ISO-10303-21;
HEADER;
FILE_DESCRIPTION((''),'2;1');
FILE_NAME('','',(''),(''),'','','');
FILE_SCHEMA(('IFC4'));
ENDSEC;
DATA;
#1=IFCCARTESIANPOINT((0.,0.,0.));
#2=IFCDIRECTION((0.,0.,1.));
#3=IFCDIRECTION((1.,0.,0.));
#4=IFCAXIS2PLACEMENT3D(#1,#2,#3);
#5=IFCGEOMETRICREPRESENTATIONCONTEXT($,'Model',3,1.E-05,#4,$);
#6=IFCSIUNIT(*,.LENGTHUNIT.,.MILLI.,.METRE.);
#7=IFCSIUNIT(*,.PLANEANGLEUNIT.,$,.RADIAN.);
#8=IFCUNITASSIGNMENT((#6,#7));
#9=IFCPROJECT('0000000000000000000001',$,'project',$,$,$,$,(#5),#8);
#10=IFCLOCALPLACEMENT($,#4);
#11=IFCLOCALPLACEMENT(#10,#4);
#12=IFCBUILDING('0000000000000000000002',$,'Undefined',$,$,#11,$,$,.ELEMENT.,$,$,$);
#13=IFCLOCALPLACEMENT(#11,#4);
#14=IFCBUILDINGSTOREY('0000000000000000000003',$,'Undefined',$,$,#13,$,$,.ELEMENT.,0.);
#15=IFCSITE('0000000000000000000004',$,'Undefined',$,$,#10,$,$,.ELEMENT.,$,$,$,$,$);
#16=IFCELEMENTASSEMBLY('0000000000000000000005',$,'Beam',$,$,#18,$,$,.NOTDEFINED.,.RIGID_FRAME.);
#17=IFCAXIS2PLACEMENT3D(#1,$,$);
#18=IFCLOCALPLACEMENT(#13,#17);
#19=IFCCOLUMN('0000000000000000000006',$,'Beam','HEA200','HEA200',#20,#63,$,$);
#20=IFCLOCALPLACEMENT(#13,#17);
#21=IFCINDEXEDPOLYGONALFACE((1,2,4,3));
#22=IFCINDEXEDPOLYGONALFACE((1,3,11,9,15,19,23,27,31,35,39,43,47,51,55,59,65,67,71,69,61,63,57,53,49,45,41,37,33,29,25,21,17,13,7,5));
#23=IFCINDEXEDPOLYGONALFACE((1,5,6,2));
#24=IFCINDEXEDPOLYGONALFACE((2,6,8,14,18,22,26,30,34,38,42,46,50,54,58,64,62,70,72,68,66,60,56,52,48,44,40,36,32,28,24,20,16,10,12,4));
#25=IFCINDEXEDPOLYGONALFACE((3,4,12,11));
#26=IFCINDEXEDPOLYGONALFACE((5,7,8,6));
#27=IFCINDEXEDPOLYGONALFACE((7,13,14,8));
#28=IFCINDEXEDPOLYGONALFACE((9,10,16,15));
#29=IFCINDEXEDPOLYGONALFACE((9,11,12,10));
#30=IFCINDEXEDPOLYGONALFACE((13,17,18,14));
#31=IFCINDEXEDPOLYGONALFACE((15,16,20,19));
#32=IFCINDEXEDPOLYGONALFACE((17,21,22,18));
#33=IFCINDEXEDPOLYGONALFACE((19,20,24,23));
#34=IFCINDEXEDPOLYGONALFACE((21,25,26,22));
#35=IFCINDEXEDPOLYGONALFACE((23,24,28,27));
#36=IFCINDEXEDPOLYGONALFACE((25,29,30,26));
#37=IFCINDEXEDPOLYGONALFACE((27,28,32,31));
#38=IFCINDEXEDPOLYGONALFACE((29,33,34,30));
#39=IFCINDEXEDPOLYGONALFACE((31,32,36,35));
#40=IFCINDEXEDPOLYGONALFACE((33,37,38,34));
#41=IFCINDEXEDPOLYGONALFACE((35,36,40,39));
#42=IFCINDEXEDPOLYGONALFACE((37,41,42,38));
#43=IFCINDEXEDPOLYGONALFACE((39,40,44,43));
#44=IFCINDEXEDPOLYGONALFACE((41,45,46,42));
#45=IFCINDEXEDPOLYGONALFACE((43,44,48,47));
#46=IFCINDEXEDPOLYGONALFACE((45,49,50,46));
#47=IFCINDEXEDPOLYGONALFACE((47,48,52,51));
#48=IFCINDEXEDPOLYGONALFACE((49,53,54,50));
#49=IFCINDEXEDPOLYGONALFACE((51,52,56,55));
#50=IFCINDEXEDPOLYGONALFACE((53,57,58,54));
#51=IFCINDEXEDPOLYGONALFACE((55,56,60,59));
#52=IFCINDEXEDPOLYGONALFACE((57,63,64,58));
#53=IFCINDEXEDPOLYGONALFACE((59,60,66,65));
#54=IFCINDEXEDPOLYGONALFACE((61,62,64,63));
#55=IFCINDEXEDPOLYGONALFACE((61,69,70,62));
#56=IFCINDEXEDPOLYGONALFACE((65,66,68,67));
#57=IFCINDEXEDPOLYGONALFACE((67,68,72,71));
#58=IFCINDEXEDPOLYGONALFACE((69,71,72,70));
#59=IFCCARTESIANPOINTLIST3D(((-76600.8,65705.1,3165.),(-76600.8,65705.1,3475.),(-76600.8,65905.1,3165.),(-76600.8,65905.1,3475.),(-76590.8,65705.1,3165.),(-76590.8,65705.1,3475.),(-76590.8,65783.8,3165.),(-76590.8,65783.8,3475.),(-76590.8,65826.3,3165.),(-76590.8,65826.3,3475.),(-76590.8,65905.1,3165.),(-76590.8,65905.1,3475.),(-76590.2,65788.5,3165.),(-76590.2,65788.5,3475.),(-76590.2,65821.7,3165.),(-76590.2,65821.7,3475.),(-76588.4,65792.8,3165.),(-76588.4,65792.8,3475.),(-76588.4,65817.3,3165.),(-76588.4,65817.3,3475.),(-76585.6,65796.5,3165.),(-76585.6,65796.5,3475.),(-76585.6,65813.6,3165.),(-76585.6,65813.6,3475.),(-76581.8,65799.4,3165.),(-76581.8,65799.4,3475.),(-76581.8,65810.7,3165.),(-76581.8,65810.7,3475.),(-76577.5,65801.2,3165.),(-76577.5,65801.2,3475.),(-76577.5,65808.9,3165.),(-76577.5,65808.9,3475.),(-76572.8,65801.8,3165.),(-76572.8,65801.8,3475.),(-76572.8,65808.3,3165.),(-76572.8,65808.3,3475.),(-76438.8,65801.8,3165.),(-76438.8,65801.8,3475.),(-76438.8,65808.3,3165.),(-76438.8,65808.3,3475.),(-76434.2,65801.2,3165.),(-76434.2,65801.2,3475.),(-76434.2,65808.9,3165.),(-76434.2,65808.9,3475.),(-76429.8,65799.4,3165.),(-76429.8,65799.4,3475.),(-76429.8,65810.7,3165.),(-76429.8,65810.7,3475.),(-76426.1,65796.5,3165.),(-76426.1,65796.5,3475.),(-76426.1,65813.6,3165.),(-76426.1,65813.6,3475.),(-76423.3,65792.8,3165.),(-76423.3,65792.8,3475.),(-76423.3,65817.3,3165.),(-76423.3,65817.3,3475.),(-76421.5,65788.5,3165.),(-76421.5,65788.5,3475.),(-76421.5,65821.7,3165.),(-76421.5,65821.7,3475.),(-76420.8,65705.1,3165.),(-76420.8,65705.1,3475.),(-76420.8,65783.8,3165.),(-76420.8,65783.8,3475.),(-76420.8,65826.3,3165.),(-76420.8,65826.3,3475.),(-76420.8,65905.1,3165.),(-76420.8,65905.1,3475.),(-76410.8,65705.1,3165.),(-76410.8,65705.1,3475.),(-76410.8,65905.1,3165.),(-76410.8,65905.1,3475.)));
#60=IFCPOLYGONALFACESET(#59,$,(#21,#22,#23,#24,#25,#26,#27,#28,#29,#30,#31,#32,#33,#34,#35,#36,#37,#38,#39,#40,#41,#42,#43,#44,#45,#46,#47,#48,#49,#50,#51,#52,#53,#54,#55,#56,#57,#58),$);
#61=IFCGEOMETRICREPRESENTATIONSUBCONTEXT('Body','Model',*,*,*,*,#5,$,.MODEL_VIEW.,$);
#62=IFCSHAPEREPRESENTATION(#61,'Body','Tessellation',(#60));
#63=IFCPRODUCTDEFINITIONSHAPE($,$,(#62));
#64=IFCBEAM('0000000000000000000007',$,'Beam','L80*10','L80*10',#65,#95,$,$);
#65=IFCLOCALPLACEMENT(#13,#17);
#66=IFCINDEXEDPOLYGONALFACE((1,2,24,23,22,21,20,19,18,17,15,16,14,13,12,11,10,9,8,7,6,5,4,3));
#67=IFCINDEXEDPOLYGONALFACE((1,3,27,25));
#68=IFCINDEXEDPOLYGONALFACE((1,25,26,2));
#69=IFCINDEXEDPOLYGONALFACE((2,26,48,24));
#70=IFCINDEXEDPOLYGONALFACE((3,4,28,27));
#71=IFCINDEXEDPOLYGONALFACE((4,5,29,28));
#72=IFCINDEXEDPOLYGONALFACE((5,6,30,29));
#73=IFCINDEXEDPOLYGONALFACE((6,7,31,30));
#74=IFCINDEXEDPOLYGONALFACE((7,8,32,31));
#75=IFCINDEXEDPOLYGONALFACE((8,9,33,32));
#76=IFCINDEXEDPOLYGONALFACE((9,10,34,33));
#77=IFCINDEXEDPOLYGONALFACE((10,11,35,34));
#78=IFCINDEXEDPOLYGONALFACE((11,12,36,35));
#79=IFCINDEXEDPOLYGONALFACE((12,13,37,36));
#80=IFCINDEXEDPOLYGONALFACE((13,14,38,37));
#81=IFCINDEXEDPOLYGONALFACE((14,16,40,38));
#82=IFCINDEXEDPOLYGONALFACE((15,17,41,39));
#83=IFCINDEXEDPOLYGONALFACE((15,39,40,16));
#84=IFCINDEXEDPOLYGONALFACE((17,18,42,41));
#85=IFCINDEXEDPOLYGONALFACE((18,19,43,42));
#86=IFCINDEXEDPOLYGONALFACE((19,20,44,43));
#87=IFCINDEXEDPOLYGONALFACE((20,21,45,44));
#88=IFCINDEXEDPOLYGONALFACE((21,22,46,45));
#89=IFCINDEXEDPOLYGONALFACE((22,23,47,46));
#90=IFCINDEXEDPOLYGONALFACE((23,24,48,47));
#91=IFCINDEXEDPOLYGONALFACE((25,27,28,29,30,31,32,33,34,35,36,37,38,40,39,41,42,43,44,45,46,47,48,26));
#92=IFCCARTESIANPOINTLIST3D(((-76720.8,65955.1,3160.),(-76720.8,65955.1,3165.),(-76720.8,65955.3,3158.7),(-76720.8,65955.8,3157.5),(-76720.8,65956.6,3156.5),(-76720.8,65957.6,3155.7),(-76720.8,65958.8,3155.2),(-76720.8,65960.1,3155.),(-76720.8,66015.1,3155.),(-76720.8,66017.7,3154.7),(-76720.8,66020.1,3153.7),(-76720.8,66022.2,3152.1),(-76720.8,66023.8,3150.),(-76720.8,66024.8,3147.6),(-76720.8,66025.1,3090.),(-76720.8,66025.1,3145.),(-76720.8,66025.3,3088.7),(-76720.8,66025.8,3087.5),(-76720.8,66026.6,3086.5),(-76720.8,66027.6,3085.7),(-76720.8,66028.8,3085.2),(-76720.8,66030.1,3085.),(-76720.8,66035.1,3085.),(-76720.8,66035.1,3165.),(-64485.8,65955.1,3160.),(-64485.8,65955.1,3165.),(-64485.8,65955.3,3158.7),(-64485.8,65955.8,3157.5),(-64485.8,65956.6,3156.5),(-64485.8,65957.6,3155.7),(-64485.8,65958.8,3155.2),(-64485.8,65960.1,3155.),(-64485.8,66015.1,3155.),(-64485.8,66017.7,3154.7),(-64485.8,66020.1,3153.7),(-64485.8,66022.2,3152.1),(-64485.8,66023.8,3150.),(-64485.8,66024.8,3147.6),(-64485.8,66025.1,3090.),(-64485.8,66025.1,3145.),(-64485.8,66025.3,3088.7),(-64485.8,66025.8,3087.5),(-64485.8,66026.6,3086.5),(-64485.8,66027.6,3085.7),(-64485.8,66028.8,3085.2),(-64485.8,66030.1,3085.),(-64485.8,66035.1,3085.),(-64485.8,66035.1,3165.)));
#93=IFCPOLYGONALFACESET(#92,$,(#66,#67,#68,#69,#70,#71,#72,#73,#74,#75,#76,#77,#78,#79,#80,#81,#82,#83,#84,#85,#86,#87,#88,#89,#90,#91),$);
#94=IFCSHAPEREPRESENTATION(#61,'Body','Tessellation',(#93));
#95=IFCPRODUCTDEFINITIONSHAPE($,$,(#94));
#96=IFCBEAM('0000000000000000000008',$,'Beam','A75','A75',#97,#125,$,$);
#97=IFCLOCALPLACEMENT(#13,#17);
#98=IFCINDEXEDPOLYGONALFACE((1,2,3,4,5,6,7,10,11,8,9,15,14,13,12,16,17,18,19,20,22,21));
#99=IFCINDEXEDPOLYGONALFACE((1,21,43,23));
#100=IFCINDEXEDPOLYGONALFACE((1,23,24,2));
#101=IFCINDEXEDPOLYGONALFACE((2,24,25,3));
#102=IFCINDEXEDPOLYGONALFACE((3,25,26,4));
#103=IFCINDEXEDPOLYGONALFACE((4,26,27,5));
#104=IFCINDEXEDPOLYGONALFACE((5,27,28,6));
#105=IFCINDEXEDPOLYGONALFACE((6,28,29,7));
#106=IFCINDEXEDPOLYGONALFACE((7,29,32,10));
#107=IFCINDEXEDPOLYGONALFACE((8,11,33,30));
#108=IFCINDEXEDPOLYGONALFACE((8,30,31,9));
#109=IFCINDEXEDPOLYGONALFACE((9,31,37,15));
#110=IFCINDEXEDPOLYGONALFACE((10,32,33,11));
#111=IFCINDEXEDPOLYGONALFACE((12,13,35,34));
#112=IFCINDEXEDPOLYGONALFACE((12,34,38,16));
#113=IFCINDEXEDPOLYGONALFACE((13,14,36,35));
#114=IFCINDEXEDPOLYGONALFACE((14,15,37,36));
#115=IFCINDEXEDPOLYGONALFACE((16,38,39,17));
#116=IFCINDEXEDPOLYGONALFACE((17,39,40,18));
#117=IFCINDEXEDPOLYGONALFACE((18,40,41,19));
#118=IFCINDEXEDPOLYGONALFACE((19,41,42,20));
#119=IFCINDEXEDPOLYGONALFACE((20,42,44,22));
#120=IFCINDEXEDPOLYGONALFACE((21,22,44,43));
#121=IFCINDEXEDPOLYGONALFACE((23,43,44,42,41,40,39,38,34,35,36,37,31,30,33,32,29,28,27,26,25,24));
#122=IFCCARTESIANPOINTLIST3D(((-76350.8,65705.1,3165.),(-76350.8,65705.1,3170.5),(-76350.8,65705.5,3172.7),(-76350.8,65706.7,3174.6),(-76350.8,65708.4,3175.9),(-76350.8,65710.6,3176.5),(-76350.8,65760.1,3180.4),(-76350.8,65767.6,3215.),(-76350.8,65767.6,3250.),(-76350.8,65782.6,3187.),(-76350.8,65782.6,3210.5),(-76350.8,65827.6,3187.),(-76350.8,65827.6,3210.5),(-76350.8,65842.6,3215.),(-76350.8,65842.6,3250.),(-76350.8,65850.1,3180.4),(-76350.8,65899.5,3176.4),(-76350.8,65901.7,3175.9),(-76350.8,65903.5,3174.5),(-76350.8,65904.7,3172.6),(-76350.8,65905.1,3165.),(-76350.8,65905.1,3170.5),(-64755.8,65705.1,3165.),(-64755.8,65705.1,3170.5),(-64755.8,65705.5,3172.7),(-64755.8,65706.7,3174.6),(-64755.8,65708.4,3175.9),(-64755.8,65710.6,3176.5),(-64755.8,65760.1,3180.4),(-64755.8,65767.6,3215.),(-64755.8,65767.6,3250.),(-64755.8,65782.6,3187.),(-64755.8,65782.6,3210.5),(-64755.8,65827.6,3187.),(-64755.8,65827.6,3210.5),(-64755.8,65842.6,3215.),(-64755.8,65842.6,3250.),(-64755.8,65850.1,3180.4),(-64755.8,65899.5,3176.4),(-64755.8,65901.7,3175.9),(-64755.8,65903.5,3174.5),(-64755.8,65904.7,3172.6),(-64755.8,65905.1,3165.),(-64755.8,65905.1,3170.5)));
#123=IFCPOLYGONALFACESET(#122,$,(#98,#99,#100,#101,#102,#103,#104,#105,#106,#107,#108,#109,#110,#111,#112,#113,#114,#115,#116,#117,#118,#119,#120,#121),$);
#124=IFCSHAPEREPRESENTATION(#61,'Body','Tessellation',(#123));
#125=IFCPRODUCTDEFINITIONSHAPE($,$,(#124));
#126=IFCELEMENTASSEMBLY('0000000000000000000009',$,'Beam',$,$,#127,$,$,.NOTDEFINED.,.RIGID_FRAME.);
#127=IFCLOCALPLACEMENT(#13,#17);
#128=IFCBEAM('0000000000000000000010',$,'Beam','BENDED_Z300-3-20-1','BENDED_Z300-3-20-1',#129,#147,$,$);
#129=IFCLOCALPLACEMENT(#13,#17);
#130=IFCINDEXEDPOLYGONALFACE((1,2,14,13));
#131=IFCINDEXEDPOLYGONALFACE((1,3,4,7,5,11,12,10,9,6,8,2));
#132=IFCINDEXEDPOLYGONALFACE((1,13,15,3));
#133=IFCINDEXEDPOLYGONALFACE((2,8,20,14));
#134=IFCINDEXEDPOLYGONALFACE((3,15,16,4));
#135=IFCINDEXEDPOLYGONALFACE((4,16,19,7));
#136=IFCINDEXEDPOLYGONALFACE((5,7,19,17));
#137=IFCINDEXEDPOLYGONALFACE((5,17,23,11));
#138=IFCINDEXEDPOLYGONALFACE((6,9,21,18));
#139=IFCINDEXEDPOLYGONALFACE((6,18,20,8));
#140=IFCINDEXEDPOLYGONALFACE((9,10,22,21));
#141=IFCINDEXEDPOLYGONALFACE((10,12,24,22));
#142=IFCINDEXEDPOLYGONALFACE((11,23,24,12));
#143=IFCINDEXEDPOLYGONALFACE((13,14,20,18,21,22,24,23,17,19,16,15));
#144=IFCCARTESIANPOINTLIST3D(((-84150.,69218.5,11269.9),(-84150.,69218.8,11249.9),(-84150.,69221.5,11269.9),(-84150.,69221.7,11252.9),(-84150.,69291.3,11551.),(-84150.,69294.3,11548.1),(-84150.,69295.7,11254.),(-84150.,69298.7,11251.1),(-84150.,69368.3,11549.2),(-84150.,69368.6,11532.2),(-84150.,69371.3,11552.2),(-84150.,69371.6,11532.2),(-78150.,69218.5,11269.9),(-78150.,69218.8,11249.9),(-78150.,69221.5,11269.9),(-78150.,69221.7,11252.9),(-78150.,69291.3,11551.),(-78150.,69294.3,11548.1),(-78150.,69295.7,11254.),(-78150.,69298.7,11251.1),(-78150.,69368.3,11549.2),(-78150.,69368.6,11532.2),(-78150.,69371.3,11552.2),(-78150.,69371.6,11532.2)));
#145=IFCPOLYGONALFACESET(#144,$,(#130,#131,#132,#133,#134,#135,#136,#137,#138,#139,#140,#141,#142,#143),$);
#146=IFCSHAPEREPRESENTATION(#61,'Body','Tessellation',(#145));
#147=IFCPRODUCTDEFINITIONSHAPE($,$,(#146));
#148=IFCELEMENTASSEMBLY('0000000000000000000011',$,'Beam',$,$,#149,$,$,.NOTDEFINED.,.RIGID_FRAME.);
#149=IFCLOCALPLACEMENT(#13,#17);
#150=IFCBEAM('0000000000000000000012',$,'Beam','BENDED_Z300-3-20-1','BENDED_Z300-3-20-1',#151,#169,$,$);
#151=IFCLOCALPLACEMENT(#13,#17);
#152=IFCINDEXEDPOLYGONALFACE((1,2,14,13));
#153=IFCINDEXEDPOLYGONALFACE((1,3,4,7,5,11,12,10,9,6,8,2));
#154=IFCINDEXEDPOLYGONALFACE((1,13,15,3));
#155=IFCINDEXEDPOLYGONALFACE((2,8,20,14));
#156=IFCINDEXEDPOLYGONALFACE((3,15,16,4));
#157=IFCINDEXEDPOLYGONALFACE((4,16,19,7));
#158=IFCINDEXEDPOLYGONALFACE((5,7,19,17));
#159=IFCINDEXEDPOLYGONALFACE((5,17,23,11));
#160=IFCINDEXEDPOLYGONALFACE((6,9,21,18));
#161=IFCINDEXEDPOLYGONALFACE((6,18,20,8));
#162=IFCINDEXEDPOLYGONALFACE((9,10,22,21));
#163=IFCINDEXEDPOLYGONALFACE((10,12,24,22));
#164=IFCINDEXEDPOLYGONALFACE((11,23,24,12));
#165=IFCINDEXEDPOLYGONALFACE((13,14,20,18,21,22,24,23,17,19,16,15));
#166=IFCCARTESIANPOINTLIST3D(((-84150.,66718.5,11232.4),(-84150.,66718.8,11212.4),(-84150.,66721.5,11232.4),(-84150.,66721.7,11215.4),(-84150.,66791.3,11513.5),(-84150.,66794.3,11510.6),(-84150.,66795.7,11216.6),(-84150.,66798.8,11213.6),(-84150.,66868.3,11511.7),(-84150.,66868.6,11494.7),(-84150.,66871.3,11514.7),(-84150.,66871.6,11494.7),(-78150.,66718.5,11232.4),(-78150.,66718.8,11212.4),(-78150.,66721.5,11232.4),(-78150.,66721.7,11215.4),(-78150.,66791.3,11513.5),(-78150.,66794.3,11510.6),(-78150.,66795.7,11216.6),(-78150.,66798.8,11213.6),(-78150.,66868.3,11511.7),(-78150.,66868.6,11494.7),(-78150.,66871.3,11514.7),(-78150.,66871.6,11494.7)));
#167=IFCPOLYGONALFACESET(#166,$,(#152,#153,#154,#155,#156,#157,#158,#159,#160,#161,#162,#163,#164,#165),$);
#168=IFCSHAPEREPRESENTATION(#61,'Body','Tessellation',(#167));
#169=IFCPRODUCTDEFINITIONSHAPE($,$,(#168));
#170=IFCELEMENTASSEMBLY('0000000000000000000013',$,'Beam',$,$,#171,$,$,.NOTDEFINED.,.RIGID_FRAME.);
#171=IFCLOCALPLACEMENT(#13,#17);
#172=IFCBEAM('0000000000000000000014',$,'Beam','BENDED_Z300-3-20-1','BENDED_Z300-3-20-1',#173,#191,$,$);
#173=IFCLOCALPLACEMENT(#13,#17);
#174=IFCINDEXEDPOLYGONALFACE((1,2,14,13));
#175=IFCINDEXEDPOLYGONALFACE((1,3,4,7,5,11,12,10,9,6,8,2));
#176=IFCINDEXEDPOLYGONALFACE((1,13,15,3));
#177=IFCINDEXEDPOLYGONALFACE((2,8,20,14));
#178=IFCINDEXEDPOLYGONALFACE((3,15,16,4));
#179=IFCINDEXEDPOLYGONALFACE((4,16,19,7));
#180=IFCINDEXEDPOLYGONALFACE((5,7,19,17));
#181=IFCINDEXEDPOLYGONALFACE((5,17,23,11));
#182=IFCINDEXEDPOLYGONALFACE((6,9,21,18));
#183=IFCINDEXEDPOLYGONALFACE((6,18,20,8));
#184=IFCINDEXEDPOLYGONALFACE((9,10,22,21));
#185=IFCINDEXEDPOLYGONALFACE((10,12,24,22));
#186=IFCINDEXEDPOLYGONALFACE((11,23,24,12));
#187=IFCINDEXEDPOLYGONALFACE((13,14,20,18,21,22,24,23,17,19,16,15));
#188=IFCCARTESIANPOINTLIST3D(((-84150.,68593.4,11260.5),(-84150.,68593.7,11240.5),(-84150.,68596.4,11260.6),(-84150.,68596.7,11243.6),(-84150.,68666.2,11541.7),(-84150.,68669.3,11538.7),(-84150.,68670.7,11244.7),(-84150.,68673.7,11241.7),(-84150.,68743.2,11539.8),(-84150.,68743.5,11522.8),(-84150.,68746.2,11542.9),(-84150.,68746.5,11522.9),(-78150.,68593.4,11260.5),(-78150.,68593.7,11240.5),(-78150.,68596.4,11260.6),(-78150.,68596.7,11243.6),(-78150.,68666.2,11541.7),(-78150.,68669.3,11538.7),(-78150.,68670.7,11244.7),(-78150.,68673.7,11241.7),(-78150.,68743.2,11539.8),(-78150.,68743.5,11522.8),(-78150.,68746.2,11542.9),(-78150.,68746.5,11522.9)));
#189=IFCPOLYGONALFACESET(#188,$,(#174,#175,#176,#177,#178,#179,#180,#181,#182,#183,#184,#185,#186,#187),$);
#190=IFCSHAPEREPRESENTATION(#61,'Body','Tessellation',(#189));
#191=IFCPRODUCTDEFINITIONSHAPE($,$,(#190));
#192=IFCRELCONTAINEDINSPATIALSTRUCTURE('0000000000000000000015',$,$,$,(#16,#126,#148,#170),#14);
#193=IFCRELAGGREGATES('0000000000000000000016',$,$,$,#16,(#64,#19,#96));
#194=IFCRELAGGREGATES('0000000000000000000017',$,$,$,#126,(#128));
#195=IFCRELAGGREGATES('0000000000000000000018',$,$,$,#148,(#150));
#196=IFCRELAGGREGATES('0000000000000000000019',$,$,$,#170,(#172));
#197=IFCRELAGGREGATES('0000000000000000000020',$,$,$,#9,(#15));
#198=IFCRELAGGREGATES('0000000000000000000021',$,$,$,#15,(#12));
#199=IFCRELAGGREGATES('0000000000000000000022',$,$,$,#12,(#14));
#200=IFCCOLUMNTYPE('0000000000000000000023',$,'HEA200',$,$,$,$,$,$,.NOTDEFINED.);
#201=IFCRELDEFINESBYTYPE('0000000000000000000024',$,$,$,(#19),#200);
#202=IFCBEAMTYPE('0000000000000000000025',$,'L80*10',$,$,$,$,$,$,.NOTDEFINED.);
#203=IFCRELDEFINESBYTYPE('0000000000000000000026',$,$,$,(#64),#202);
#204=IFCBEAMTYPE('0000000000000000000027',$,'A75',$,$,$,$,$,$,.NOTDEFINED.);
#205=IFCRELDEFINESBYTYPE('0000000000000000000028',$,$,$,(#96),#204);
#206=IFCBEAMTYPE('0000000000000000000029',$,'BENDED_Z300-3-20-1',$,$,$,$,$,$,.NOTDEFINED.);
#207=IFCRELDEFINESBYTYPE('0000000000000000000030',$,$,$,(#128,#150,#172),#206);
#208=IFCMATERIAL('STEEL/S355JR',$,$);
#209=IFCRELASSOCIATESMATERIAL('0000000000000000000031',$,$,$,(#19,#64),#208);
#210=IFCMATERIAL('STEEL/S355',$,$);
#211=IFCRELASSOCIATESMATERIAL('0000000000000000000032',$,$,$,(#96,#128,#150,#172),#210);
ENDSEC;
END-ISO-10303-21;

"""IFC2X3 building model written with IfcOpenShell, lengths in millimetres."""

from ifc_helpers import new_model, si_unit, frame, origin_with_axes, origin_2d_with_axis, place, context, subcontext, project, spatial, polyline, i_section, l_section, outline, extrude, material, type_object, element, aggregate, save


model = new_model("IFC2X3")

# Units and contexts
model_context = context("Model", 3, precision=1e-05, world=origin_with_axes())
body_context = subcontext(model_context, "Body", "Model", "MODEL_VIEW")
ifc_project = project(units=[si_unit("LENGTHUNIT", "METRE", prefix="MILLI"), si_unit("PLANEANGLEUNIT", "RADIAN")], contexts=[model_context])

# Site, building, storey
site_placement = place(None, origin_with_axes())
site = spatial("IfcSite", under=ifc_project, at=site_placement, Name="Undefined", CompositionType="ELEMENT")
building_placement = place(site_placement, origin_with_axes())
building = spatial("IfcBuilding", under=site, at=building_placement, Name="Undefined", CompositionType="ELEMENT")
storey_placement = place(building_placement, origin_with_axes())
storey = spatial("IfcBuildingStorey", under=building, at=storey_placement, Name="Undefined", CompositionType="ELEMENT", Elevation=0.0)

# Element assembly, column, beams
assembly_1_placement = place(storey_placement, origin_with_axes())
assembly_1 = element("IfcElementAssembly", 1, at=assembly_1_placement, inside=storey, Name="Beam", AssemblyPlace="NOTDEFINED", PredefinedType="RIGID_FRAME")
ifc_material_1 = material(Name="STEEL/S355JR")
column_type = type_object("IfcColumnType", Name="HEA200", PredefinedType="NOTDEFINED")
column_placement = place(assembly_1_placement, frame((-76505.8, 65805.1, 3165.0), z_axis=(0.0, 0.0, 1.0), x_axis=(-1.0, 0.0, 0.0)))
column = element("IfcColumn", 2, at=column_placement, type_object=column_type, material=ifc_material_1, Name="Beam", Description="HEA200", ObjectType="HEA200", context=body_context, shape_type="SweptSolid", body=[
    extrude(i_section(OverallWidth=200.0, OverallDepth=190.0, WebThickness=6.5, FlangeThickness=10.0, FilletRadius=18.0, at=origin_2d_with_axis()), frame((0.0, 0.0, 310.0), z_axis=(0.0, 0.0, -1.0), x_axis=(0.0, 1.0, 0.0)), (0.0, 0.0, 1.0), 310.0),
])
beam_type_1 = type_object("IfcBeamType", Name="L80*10", PredefinedType="NOTDEFINED")
beam_1_placement = place(assembly_1_placement, frame((-76720.8, 65995.1, 3125.0), z_axis=(0.0, -1.0, 0.0), x_axis=(1.0, 0.0, 0.0)))
beam_1 = element("IfcBeam", 3, at=beam_1_placement, type_object=beam_type_1, material=ifc_material_1, Name="Beam", Description="L80*10", ObjectType="L80*10", context=body_context, shape_type="SweptSolid", body=[
    extrude(l_section(Depth=80.0, Width=80.0, Thickness=10.0, FilletRadius=10.0, EdgeRadius=5.0, at=origin_2d_with_axis()), frame((12235.0, 0.0, 0.0), z_axis=(-1.0, 0.0, 0.0), x_axis=(0.0, -1.0, 0.0)), (0.0, 0.0, 1.0), 12235.0),
])
ifc_material_2 = material(Name="STEEL/S355")
beam_type_2 = type_object("IfcBeamType", Name="A75", PredefinedType="NOTDEFINED")
beam_2_placement = place(assembly_1_placement, frame((-76350.8, 65805.1, 3207.5), z_axis=(0.0, 0.000118, 1.0), x_axis=(1.0, 0.0, 0.0)))
beam_2 = element("IfcBeam", 4, at=beam_2_placement, type_object=beam_type_2, material=ifc_material_2, Name="Beam", Description="A75", ObjectType="A75", context=body_context, shape_type="SweptSolid", body=[
    extrude(outline(polyline([(100.0, -42.5), (-100.0, -42.5), (-100.0, -37.0), (-99.6, -34.9), (-98.4, -33.0), (-96.6, -31.6), (-94.5, -31.1), (-45.0, -27.1), (-22.5, -20.5), (-22.5, 3.0), (-37.5, 7.5), (-37.5, 42.5), (37.5, 42.5), (37.5, 7.5), (22.5, 3.0), (22.5, -20.5), (45.0, -27.1), (94.5, -31.1), (96.6, -31.6), (98.4, -33.0), (99.6, -34.9), (100.0, -37.0), (100.0, -42.5)])), frame((11595.0, 0.0, 0.0), z_axis=(-1.0, 0.0, 0.0), x_axis=(0.0, -1.0, 0.0)), (0.0, 0.0, 1.0), 11595.0),
])
aggregate(assembly_1, [beam_1, column, beam_2])

# Element assemblies, beams
assembly_2_placement = place(storey_placement, origin_with_axes())
assembly_2 = element("IfcElementAssembly", 5, at=assembly_2_placement, inside=storey, Name="Beam", AssemblyPlace="NOTDEFINED", PredefinedType="RIGID_FRAME")
beam_type_3 = type_object("IfcBeamType", Name="BENDED_Z300-3-20-1", PredefinedType="NOTDEFINED")
beam_3_placement = place(assembly_2_placement, frame((-78150.0, 69295.0, 11401.1), z_axis=(0.0, -0.014963, 0.999888), x_axis=(-1.0, 0.0, 0.0)))
beam_3 = element("IfcBeam", 6, at=beam_3_placement, type_object=beam_type_3, material=ifc_material_2, Name="Beam", Description="BENDED_Z300-3-20-1", ObjectType="BENDED_Z300-3-20-1", context=body_context, shape_type="SweptSolid", body=[
    extrude(outline(polyline([(1.5, -150.0), (-78.5, -150.0), (-78.5, -130.0), (-75.5, -130.0), (-75.5, -147.0), (-1.5, -147.0), (-1.5, 150.0), (78.5, 150.0), (78.5, 130.0), (75.5, 130.0), (75.5, 147.0), (1.5, 147.0), (1.5, -150.0)])), frame((6000.0, 0.0, 0.0), z_axis=(-1.0, 0.0, 0.0), x_axis=(0.0, -1.0, 0.0)), (0.0, 0.0, 1.0), 6000.0),
])
aggregate(assembly_2, [beam_3])
assembly_3_placement = place(storey_placement, origin_with_axes())
assembly_3 = element("IfcElementAssembly", 7, at=assembly_3_placement, inside=storey, Name="Beam", AssemblyPlace="NOTDEFINED", PredefinedType="RIGID_FRAME")
beam_4_placement = place(assembly_3_placement, frame((-78150.0, 66795.0, 11363.6), z_axis=(0.0, -0.014963, 0.999888), x_axis=(-1.0, 0.0, 0.0)))
beam_4 = element("IfcBeam", 8, at=beam_4_placement, type_object=beam_type_3, material=ifc_material_2, Name="Beam", Description="BENDED_Z300-3-20-1", ObjectType="BENDED_Z300-3-20-1", context=body_context, shape_type="SweptSolid", body=[
    extrude(outline(polyline([(1.5, -150.0), (-78.5, -150.0), (-78.5, -130.0), (-75.5, -130.0), (-75.5, -147.0), (-1.5, -147.0), (-1.5, 150.0), (78.5, 150.0), (78.5, 130.0), (75.5, 130.0), (75.5, 147.0), (1.5, 147.0), (1.5, -150.0)])), frame((6000.0, 0.0, 0.0), z_axis=(-1.0, 0.0, 0.0), x_axis=(0.0, -1.0, 0.0)), (0.0, 0.0, 1.0), 6000.0),
])
aggregate(assembly_3, [beam_4])
assembly_4_placement = place(storey_placement, origin_with_axes())
assembly_4 = element("IfcElementAssembly", 9, at=assembly_4_placement, inside=storey, Name="Beam", AssemblyPlace="NOTDEFINED", PredefinedType="RIGID_FRAME")
beam_5_placement = place(assembly_4_placement, frame((-78150.0, 68670.0, 11391.7), z_axis=(0.0, -0.014963, 0.999888), x_axis=(-1.0, 0.0, 0.0)))
beam_5 = element("IfcBeam", 10, at=beam_5_placement, type_object=beam_type_3, material=ifc_material_2, Name="Beam", Description="BENDED_Z300-3-20-1", ObjectType="BENDED_Z300-3-20-1", context=body_context, shape_type="SweptSolid", body=[
    extrude(outline(polyline([(1.5, -150.0), (-78.5, -150.0), (-78.5, -130.0), (-75.5, -130.0), (-75.5, -147.0), (-1.5, -147.0), (-1.5, 150.0), (78.5, 150.0), (78.5, 130.0), (75.5, 130.0), (75.5, 147.0), (1.5, 147.0), (1.5, -150.0)])), frame((6000.0, 0.0, 0.0), z_axis=(-1.0, 0.0, 0.0), x_axis=(0.0, -1.0, 0.0)), (0.0, 0.0, 1.0), 6000.0),
])
aggregate(assembly_4, [beam_5])

save(model, "model.ifc")
